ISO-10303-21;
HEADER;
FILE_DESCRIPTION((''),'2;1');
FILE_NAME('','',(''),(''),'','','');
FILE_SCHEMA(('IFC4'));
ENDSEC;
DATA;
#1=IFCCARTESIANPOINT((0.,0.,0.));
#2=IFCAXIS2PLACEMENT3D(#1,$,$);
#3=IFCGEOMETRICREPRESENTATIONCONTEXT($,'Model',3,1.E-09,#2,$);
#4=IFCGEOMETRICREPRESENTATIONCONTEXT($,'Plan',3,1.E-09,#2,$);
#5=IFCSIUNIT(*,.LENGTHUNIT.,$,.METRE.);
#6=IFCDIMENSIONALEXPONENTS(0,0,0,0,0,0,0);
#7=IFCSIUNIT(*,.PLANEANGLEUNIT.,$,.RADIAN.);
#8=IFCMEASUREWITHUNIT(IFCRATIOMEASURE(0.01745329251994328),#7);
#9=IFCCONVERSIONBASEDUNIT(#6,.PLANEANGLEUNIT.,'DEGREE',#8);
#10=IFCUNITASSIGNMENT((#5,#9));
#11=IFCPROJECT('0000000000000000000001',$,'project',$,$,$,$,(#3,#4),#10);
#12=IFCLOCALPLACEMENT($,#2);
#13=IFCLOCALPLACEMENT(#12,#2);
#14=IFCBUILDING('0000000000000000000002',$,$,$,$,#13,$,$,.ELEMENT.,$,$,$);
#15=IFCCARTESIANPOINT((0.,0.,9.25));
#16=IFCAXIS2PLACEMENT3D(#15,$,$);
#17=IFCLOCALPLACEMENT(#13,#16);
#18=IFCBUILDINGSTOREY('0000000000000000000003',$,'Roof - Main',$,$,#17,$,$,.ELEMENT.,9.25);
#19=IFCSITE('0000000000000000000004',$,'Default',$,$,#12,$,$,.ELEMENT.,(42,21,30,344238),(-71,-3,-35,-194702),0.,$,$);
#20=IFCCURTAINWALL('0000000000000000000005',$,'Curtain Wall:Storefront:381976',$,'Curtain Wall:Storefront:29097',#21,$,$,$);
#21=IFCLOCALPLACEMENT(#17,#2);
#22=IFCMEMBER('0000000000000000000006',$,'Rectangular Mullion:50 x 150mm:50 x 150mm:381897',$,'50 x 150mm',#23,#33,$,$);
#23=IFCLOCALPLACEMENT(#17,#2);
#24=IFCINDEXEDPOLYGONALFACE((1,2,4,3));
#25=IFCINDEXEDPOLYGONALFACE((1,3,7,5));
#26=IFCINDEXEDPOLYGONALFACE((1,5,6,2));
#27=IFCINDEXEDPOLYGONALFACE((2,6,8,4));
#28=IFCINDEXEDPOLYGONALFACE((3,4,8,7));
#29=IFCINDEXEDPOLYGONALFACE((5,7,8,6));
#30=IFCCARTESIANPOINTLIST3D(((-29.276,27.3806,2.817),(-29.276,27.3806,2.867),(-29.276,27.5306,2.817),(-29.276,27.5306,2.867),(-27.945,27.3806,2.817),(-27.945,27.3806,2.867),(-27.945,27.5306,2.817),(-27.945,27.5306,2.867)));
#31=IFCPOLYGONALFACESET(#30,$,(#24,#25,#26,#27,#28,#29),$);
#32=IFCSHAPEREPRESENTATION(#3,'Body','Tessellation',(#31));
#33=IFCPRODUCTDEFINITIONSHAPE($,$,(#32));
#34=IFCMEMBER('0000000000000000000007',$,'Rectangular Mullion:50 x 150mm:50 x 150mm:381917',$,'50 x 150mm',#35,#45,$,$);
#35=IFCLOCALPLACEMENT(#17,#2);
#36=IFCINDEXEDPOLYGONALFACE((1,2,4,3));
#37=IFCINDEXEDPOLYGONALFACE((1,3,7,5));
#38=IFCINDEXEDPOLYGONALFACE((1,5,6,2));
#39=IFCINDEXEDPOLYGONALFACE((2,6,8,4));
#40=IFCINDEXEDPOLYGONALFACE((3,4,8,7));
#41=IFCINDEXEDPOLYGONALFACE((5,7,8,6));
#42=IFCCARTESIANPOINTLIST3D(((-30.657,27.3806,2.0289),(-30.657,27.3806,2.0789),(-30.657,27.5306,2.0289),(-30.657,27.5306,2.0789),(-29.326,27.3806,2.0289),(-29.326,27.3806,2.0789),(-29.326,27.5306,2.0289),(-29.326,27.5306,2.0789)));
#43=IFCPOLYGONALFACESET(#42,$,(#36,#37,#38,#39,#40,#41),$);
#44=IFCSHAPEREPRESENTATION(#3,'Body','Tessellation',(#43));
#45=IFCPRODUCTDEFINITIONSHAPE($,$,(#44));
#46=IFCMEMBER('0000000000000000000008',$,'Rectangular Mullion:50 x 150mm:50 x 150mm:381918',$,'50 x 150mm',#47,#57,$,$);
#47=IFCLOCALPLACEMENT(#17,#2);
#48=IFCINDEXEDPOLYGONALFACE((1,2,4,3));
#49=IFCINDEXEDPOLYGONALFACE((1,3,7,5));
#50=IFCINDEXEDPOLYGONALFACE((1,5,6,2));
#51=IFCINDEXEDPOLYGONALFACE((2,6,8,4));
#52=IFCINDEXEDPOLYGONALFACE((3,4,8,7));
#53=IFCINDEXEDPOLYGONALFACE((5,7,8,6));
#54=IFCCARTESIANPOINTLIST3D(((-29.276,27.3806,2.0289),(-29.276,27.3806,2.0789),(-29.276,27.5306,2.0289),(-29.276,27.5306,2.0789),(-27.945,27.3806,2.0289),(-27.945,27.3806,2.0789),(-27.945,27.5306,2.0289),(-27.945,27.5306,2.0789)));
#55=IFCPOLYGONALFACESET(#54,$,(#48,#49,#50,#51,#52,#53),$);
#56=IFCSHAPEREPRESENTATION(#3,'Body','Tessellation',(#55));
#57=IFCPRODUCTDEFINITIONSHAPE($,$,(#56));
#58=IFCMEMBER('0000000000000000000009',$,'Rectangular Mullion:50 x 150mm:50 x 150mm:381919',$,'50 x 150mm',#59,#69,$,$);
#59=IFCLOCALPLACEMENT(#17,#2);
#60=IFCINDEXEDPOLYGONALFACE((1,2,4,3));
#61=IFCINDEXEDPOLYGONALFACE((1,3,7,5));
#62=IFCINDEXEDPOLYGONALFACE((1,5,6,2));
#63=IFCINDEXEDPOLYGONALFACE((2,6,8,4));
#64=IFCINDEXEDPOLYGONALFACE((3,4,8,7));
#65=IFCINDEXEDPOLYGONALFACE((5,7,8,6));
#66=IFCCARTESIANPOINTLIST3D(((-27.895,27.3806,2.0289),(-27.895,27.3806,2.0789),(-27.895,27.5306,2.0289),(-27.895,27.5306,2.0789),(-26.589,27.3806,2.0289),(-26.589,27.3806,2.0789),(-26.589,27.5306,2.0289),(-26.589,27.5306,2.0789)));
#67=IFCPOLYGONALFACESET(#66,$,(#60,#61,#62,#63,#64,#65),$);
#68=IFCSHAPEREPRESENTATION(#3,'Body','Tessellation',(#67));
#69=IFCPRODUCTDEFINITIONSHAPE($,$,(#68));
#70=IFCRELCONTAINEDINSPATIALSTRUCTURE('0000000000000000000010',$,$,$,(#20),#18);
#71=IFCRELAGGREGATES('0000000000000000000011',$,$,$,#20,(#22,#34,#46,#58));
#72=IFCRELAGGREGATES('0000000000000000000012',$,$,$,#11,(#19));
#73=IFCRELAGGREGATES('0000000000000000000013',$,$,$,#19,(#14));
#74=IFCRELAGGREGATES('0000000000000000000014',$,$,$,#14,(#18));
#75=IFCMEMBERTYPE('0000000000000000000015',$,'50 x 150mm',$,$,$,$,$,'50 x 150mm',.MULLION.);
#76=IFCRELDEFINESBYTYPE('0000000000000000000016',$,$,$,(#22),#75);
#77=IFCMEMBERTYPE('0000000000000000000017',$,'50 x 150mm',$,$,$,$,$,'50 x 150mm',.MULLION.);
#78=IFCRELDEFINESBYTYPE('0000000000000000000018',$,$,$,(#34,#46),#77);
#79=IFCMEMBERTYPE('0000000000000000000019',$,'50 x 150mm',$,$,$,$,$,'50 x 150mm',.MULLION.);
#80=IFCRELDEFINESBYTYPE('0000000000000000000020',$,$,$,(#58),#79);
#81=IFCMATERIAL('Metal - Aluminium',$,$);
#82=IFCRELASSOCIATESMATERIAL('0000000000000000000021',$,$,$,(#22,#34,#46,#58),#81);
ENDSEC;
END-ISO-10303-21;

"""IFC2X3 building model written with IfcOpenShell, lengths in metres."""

from ifc_helpers import new_model, entity, si_unit, converted_unit, frame, origin, origin_2d_with_axis, place, context, project, spatial, rectangle, extrude, source, transform, mapped, material, type_object, type_shapes, element, aggregate, save


model = new_model("IFC2X3")

# Units and contexts
model_context = context("Model", 3, precision=1e-09, world=origin())
plan_context = context("Plan", 3, precision=1e-09, world=origin())
ifc_project = project(units=[si_unit("LENGTHUNIT", "METRE"), converted_unit("PLANEANGLEUNIT", "DEGREE", entity("IfcRatioMeasure", 0.01745329251994328), si_unit("PLANEANGLEUNIT", "RADIAN"), dimensions=[0, 0, 0, 0, 0, 0, 0])], contexts=[model_context, plan_context])

# Site, building, storey
site_placement = place(None, origin())
site = spatial("IfcSite", under=ifc_project, at=site_placement, Name="Default", CompositionType="ELEMENT", RefLatitude=(42, 21, 30, 344238), RefLongitude=(-71, -3, -35, -194702), RefElevation=0.0)
building_placement = place(site_placement, origin())
building = spatial("IfcBuilding", under=site, at=building_placement, CompositionType="ELEMENT")
storey_placement = place(building_placement, frame((0.0, 0.0, 9.25)))
storey = spatial("IfcBuildingStorey", under=building, at=storey_placement, Name="Roof - Main", CompositionType="ELEMENT", Elevation=9.25)

# Curtain wall
curtain_wall_1_placement = place(storey_placement, origin())
curtain_wall_1 = element("IfcCurtainWall", 1, at=curtain_wall_1_placement, inside=storey, Name="Curtain Wall:Storefront:381976", ObjectType="Curtain Wall:Storefront:29097")
ifc_material_1 = material(Name="Metal - Aluminium")

# Members
member_type_1 = type_object("IfcMemberType", Name="50 x 150mm", ElementType="50 x 150mm", PredefinedType="MULLION")
shared_shape_1 = source(origin(), model_context, "Body", "SweptSolid", [
    extrude(rectangle(XDim=0.05, YDim=0.15, at=origin_2d_with_axis()), frame((-0.025, 0.0, -1.331), z_axis=(0.0, 0.0, 1.0), x_axis=(-1.0, 0.0, 0.0)), (0.0, 0.0, 1.0), 1.331),
])
type_shapes(member_type_1, [shared_shape_1])
member_1_placement = place(storey_placement, frame((-27.945, 27.4556, 2.867), z_axis=(1.0, 0.0, 0.0), x_axis=(0.0, 0.0, 1.0)))
member_1 = element("IfcMember", 2, at=member_1_placement, type_object=member_type_1, material=ifc_material_1, Name="Rectangular Mullion:50 x 150mm:50 x 150mm:381897", ObjectType="50 x 150mm", context=model_context, shape_type="MappedRepresentation", body=[
    mapped(shared_shape_1, transform((0.0, 0.0, 0.0), scale=1.0)),
])
member_type_2 = type_object("IfcMemberType", Name="50 x 150mm", ElementType="50 x 150mm", PredefinedType="MULLION")
shared_shape_2 = source(origin(), model_context, "Body", "SweptSolid", [
    extrude(rectangle(XDim=0.05, YDim=0.15, at=origin_2d_with_axis()), frame((0.0, 0.0, -1.331), z_axis=(0.0, 0.0, 1.0), x_axis=(-1.0, 0.0, 0.0)), (0.0, 0.0, 1.0), 1.331),
])
type_shapes(member_type_2, [shared_shape_2])
member_2_placement = place(storey_placement, frame((-29.326, 27.4556, 2.0539), z_axis=(1.0, 0.0, 0.0), x_axis=(0.0, 0.0, 1.0)))
member_2 = element("IfcMember", 3, at=member_2_placement, type_object=member_type_2, material=ifc_material_1, Name="Rectangular Mullion:50 x 150mm:50 x 150mm:381917", ObjectType="50 x 150mm", context=model_context, shape_type="MappedRepresentation", body=[
    mapped(shared_shape_2, transform((0.0, 0.0, 0.0), scale=1.0)),
])
member_3_placement = place(storey_placement, frame((-27.945, 27.4556, 2.0539), z_axis=(1.0, 0.0, 0.0), x_axis=(0.0, 0.0, 1.0)))
member_3 = element("IfcMember", 4, at=member_3_placement, type_object=member_type_2, material=ifc_material_1, Name="Rectangular Mullion:50 x 150mm:50 x 150mm:381918", ObjectType="50 x 150mm", context=model_context, shape_type="MappedRepresentation", body=[
    mapped(shared_shape_2, transform((0.0, 0.0, 0.0), scale=1.0)),
])
member_type_3 = type_object("IfcMemberType", Name="50 x 150mm", ElementType="50 x 150mm", PredefinedType="MULLION")
shared_shape_3 = source(origin(), model_context, "Body", "SweptSolid", [
    extrude(rectangle(XDim=0.05, YDim=0.15, at=origin_2d_with_axis()), frame((0.0, 0.0, -1.306), z_axis=(0.0, 0.0, 1.0), x_axis=(-1.0, 0.0, 0.0)), (0.0, 0.0, 1.0), 1.306),
])
type_shapes(member_type_3, [shared_shape_3])
member_4_placement = place(storey_placement, frame((-26.589, 27.4556, 2.0539), z_axis=(1.0, 0.0, 0.0), x_axis=(0.0, 0.0, 1.0)))
member_4 = element("IfcMember", 5, at=member_4_placement, type_object=member_type_3, material=ifc_material_1, Name="Rectangular Mullion:50 x 150mm:50 x 150mm:381919", ObjectType="50 x 150mm", context=model_context, shape_type="MappedRepresentation", body=[
    mapped(shared_shape_3, transform((0.0, 0.0, 0.0), scale=1.0)),
])

aggregate(curtain_wall_1, [member_1, member_2, member_3, member_4])

save(model, "model.ifc")
